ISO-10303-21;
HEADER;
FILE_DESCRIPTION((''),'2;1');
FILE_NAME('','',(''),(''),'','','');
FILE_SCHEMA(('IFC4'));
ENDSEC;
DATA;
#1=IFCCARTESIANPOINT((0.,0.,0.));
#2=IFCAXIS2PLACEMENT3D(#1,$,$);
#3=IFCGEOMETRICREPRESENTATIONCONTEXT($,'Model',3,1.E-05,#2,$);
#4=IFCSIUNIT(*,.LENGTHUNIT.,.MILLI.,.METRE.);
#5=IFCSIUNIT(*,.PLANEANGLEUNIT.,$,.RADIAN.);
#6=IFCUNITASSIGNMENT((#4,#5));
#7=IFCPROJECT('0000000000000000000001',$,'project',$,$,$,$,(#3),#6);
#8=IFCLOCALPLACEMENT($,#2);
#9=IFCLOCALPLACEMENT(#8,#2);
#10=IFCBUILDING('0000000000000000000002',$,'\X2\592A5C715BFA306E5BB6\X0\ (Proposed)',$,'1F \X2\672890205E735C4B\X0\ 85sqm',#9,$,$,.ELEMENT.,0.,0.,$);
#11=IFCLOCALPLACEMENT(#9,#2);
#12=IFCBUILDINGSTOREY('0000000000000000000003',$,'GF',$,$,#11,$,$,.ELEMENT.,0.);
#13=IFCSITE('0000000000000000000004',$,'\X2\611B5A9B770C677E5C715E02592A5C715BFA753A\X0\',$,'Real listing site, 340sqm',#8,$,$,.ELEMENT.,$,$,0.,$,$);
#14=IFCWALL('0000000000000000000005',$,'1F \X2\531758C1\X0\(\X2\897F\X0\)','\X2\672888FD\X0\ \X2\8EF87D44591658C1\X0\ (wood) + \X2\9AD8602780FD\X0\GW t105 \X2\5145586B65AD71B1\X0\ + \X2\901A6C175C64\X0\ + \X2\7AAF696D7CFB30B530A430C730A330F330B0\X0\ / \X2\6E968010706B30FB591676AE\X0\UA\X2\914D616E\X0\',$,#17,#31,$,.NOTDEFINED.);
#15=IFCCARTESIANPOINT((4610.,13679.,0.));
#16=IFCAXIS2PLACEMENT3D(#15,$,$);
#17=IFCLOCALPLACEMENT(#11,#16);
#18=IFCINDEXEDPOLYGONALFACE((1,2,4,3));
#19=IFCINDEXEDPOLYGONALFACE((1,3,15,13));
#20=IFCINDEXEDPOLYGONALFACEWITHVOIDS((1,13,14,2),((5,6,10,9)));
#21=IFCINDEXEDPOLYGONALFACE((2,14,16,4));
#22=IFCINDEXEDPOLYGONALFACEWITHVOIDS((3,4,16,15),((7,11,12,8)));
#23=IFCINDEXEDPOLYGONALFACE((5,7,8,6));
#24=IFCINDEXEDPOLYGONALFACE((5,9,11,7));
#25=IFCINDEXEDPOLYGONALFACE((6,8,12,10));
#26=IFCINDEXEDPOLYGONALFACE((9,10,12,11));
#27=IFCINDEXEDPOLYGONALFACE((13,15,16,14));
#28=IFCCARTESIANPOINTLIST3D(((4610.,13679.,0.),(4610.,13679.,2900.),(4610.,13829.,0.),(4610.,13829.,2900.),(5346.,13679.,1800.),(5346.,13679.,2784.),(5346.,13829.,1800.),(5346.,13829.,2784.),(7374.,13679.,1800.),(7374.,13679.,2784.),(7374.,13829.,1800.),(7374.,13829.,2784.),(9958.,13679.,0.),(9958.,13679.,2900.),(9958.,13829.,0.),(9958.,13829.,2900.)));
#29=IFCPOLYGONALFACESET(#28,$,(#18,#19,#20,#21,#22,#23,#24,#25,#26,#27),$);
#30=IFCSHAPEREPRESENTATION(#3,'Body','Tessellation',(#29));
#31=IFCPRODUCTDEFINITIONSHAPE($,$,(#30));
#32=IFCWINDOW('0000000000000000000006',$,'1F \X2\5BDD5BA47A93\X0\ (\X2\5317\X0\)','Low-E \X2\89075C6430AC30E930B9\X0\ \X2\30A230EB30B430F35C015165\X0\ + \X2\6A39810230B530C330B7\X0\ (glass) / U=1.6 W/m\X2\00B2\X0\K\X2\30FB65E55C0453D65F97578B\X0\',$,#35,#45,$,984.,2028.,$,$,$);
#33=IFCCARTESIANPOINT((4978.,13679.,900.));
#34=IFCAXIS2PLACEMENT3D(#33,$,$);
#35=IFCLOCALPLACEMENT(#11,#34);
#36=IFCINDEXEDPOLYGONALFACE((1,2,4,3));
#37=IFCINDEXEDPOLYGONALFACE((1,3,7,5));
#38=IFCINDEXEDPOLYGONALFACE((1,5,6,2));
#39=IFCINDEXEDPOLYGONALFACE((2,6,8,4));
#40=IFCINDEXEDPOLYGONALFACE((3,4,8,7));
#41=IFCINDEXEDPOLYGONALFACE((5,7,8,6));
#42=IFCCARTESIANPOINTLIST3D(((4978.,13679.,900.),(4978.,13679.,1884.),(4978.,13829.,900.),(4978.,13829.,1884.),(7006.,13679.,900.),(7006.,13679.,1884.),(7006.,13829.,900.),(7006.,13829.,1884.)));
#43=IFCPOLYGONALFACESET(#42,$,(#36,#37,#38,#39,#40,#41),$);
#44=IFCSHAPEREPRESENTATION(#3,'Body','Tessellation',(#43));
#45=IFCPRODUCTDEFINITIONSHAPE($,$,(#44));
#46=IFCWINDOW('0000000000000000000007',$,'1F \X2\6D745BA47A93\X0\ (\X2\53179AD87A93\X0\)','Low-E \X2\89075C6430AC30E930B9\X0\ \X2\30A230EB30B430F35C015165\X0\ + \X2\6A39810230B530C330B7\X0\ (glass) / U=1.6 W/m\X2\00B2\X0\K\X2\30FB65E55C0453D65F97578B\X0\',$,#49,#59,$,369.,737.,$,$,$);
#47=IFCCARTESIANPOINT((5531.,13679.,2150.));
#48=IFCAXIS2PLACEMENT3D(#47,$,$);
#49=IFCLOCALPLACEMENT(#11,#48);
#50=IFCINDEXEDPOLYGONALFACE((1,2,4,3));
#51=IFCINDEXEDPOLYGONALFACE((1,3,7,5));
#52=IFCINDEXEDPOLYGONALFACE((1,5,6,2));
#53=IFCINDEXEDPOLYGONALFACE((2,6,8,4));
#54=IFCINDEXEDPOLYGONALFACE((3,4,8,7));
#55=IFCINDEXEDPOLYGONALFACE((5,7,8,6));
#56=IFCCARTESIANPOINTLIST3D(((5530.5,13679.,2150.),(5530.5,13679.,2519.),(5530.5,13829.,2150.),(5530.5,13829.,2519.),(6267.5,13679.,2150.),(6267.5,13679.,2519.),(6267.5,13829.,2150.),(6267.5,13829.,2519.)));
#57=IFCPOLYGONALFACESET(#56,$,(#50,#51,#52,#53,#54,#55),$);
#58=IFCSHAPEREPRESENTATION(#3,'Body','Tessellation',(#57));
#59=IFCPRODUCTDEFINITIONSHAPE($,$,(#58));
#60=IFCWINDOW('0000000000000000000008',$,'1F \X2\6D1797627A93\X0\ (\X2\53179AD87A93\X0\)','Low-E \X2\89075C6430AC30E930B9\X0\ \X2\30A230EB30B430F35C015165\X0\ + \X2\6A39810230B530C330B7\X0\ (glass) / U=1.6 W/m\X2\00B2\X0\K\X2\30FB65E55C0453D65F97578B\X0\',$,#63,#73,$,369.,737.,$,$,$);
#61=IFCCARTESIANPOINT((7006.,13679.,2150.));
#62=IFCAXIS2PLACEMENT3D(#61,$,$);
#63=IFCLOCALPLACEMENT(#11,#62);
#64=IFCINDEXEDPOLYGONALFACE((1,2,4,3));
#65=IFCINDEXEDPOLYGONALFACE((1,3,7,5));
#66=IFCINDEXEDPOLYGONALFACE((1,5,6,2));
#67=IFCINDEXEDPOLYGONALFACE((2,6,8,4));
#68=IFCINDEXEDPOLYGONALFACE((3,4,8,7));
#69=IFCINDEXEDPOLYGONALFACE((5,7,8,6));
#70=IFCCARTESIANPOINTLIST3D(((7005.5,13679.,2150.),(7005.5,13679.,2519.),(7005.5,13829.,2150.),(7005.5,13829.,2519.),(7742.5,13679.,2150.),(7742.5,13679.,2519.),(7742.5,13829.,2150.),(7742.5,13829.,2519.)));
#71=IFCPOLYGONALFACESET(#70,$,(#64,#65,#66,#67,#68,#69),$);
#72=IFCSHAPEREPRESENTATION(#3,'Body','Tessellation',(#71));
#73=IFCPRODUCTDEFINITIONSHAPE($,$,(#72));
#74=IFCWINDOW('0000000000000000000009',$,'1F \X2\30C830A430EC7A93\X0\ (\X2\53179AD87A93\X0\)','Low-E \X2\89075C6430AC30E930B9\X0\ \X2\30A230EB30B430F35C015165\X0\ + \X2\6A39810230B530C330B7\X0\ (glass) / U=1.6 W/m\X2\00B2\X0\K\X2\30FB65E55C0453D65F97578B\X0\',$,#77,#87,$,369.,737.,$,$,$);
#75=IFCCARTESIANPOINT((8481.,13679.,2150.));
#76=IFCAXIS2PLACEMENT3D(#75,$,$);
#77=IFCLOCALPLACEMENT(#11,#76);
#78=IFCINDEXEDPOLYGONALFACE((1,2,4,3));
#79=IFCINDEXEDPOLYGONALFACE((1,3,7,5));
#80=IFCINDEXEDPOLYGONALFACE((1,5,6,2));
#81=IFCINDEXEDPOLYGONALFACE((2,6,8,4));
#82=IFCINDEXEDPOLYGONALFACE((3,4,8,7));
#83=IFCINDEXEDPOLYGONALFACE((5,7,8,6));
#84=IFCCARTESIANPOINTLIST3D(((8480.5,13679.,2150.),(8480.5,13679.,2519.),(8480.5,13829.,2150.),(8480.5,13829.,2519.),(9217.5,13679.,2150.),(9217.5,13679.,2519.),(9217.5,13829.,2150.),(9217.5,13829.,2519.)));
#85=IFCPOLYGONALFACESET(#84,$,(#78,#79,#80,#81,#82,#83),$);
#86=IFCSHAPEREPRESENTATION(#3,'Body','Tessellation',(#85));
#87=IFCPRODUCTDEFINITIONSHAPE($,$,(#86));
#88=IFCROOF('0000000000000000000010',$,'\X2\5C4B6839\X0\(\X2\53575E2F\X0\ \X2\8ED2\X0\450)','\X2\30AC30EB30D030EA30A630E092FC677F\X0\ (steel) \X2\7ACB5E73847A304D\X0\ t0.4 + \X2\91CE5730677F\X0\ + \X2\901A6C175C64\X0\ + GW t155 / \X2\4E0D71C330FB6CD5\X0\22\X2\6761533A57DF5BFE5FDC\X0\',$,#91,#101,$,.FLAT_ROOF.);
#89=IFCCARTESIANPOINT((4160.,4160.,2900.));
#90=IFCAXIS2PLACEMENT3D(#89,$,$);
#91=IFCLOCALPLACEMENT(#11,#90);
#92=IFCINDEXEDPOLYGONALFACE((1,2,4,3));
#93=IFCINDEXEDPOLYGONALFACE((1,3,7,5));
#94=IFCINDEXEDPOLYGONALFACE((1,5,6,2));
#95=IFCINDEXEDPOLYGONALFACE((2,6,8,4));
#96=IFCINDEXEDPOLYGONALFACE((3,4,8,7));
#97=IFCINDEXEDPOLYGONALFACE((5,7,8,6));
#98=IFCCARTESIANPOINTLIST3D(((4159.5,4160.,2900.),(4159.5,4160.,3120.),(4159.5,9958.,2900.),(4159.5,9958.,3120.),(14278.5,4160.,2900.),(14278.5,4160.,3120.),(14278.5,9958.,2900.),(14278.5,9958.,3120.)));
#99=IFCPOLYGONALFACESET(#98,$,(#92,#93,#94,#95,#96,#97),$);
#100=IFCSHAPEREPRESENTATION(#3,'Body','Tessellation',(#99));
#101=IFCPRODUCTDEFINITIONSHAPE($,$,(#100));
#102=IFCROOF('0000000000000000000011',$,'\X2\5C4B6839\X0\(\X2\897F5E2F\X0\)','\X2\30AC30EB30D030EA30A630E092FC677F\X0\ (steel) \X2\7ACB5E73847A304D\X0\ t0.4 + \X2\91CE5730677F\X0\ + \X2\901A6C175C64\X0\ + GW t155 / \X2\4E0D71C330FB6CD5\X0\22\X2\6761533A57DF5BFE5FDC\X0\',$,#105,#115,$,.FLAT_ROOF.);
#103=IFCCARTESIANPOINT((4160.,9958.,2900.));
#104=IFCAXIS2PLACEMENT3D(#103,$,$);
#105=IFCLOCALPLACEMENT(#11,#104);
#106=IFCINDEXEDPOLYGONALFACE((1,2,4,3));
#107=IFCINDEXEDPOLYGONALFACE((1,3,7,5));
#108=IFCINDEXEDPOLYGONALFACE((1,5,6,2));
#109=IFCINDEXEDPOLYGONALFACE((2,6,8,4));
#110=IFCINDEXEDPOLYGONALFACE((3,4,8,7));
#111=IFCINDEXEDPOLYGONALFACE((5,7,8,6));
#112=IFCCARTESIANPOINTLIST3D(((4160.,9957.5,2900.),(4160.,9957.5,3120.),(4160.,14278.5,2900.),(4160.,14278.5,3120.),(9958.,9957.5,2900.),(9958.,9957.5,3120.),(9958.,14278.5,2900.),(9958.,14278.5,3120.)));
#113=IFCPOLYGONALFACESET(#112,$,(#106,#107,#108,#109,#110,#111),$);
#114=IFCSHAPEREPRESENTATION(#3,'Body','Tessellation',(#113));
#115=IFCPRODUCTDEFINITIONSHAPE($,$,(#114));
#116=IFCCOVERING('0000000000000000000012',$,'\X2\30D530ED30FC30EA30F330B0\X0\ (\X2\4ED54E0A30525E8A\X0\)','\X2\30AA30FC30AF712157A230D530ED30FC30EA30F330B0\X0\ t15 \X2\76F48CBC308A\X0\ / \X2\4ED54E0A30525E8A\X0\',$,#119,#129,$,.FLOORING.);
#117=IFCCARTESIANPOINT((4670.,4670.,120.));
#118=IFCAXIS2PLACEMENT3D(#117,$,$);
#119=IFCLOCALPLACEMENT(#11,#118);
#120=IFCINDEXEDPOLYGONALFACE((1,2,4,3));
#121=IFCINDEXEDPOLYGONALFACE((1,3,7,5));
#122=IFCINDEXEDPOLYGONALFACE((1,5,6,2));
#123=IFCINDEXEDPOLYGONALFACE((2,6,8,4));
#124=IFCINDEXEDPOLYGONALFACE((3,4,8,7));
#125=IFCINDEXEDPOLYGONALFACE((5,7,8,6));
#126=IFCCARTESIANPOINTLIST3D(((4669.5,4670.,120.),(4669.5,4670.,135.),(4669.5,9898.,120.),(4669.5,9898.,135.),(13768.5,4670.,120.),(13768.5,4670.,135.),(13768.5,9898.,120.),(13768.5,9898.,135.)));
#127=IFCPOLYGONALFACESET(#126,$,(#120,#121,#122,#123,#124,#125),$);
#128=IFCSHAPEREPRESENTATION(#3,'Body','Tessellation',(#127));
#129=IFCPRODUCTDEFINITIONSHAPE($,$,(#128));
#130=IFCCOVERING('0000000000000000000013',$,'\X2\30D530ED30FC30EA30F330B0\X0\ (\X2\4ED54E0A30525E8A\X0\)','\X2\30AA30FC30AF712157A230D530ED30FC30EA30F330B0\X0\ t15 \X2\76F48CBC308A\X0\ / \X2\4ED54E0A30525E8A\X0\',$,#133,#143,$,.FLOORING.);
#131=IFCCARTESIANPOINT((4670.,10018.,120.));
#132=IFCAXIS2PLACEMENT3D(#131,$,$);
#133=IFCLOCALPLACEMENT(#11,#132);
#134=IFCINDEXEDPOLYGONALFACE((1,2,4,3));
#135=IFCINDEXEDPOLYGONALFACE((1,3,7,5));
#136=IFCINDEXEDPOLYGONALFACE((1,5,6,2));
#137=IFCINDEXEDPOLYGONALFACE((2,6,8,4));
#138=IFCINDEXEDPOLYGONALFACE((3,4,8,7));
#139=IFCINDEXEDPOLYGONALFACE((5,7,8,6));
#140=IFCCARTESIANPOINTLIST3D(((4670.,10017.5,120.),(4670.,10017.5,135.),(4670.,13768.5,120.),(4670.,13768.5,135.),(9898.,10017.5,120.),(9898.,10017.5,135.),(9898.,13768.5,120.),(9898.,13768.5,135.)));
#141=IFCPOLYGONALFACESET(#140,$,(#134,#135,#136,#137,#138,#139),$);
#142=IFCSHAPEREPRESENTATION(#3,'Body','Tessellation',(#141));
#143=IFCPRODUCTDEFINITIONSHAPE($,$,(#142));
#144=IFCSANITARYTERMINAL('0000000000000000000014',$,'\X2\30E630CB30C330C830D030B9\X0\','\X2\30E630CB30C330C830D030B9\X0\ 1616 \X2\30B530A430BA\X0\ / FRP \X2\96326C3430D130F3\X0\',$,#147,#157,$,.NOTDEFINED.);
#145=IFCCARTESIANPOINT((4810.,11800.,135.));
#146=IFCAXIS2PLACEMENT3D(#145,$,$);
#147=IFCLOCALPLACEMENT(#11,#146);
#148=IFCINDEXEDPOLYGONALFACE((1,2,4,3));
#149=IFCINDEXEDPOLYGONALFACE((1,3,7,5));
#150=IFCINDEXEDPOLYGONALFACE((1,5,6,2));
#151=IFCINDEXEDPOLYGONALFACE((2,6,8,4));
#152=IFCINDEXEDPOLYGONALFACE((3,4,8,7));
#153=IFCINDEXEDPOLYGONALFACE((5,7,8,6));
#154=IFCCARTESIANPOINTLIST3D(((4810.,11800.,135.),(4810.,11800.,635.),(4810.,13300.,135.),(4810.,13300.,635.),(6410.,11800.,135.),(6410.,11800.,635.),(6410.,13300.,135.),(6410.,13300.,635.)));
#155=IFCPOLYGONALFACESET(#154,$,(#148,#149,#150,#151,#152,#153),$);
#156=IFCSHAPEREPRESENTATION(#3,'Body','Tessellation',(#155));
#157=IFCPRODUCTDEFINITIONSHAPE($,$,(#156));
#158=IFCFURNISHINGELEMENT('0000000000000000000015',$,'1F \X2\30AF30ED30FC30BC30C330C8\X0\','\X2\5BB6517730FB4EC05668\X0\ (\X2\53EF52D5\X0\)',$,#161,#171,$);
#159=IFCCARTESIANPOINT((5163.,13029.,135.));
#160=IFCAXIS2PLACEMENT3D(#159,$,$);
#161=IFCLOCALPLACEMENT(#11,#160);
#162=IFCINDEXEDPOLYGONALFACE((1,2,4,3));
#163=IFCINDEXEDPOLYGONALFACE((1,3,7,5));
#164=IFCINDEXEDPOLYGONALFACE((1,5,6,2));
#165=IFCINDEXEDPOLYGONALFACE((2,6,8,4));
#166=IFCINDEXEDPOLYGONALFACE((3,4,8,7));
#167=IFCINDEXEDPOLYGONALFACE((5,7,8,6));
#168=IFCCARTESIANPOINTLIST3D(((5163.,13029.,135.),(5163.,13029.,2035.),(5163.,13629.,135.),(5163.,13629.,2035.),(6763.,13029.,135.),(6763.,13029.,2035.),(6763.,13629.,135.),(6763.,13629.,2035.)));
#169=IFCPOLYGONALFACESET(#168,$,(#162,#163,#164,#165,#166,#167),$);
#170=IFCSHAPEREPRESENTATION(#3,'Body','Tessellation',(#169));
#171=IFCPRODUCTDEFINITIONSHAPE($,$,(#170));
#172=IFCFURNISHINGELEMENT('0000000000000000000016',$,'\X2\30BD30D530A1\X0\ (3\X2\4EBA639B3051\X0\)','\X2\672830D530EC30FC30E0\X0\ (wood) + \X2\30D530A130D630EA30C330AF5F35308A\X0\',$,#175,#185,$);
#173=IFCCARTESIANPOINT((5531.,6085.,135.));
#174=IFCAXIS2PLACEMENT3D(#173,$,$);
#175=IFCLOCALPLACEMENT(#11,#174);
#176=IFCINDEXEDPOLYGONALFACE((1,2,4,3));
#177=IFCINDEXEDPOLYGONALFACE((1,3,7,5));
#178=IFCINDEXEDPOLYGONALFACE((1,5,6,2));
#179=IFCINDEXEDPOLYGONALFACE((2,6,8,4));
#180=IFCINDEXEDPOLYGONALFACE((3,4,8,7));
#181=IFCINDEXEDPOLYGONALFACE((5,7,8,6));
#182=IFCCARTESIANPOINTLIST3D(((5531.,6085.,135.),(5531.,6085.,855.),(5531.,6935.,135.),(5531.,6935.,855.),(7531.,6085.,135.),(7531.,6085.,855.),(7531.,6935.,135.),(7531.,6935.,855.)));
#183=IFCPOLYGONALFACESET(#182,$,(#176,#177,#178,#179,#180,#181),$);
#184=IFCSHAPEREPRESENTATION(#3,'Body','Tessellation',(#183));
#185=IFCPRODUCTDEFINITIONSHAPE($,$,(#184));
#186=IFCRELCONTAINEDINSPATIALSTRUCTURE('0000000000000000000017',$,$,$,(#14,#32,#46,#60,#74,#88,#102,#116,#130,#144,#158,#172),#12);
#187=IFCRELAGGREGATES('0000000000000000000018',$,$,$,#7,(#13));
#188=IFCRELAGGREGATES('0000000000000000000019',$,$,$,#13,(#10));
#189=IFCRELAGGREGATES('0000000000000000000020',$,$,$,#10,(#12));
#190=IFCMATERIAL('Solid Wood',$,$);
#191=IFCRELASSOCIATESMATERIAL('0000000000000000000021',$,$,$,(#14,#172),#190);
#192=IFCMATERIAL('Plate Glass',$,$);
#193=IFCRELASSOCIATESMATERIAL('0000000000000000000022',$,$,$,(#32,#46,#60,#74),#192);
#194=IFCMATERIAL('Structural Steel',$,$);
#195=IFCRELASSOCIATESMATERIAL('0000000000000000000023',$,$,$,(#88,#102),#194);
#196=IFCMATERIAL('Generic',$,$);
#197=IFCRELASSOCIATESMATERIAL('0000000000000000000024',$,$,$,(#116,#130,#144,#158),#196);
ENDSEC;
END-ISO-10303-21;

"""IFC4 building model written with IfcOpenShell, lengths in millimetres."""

from ifc_helpers import new_model, si_unit, frame, frame_2d, origin, place, context, project, spatial, rectangle, extrude, material, element, fill, save


model = new_model("IFC4")

# Units and contexts
model_context = context("Model", 3, precision=1e-05, world=origin())
ifc_project = project(units=[si_unit("LENGTHUNIT", "METRE", prefix="MILLI"), si_unit("PLANEANGLEUNIT", "RADIAN")], contexts=[model_context])

# Site, building, storey
site_placement = place(None, origin())
site = spatial("IfcSite", under=ifc_project, at=site_placement, Name="愛媛県松山市太山寺町", ObjectType="Real listing site, 340sqm", CompositionType="ELEMENT", RefElevation=0.0)
building_placement = place(site_placement, origin())
building = spatial("IfcBuilding", under=site, at=building_placement, Name="太山寺の家 (Proposed)", ObjectType="1F 木造平屋 85sqm", CompositionType="ELEMENT", ElevationOfRefHeight=0.0, ElevationOfTerrain=0.0)
storey_placement = place(building_placement, origin())
storey = spatial("IfcBuildingStorey", under=building, at=storey_placement, Name="GF", CompositionType="ELEMENT", Elevation=0.0)

# Shared definitions
ifc_material_1 = material(Name="Solid Wood")

# Shared definitions
ifc_material_2 = material(Name="Plate Glass")

# Wall, openings, windows
wall_1_placement = place(storey_placement, frame((4610.0, 13679.0, 0.0)))
wall_1 = element("IfcWall", 1, at=wall_1_placement, inside=storey, material=ifc_material_1, Name="1F 北壁(西)", Description="木製 軸組外壁 (wood) + 高性能GW t105 充填断熱 + 通気層 + 窯業系サイディング / 準耐火・外皮UA配慮", PredefinedType="NOTDEFINED", context=model_context, shape_type="SweptSolid", body=[
    extrude(rectangle(XDim=5348.0, YDim=150.0, at=frame_2d((2674.0, 75.0))), frame((4610.0, 13679.0, 0.0)), (0.0, 0.0, 1.0), 2900.0),
])
opening_1_placement = place(storey_placement, frame((4978.0, 13679.0, 900.0)))
opening_1 = element("IfcOpeningElement", 2, at=opening_1_placement, cuts=wall_1, PredefinedType="NOTDEFINED", context=model_context, shape_type="SweptSolid", body=[
    extrude(rectangle(XDim=2028.0, YDim=150.0, at=frame_2d((1014.0, 75.0))), frame((4978.0, 13679.0, 900.0)), (0.0, 0.0, 1.0), 984.0),
])
opening_2_placement = place(storey_placement, frame((5531.0, 13679.0, 2150.0)))
opening_2 = element("IfcOpeningElement", 3, at=opening_2_placement, cuts=wall_1, PredefinedType="NOTDEFINED", context=model_context, shape_type="SweptSolid", body=[
    extrude(rectangle(XDim=737.0, YDim=150.0, at=frame_2d((368.0, 75.0))), frame((5531.0, 13679.0, 2150.0)), (0.0, 0.0, 1.0), 369.0),
])
opening_3_placement = place(storey_placement, frame((7006.0, 13679.0, 2150.0)))
opening_3 = element("IfcOpeningElement", 4, at=opening_3_placement, cuts=wall_1, PredefinedType="NOTDEFINED", context=model_context, shape_type="SweptSolid", body=[
    extrude(rectangle(XDim=737.0, YDim=150.0, at=frame_2d((368.0, 75.0))), frame((7006.0, 13679.0, 2150.0)), (0.0, 0.0, 1.0), 369.0),
])
opening_4_placement = place(storey_placement, frame((8481.0, 13679.0, 2150.0)))
opening_4 = element("IfcOpeningElement", 5, at=opening_4_placement, cuts=wall_1, PredefinedType="NOTDEFINED", context=model_context, shape_type="SweptSolid", body=[
    extrude(rectangle(XDim=737.0, YDim=150.0, at=frame_2d((368.0, 75.0))), frame((8481.0, 13679.0, 2150.0)), (0.0, 0.0, 1.0), 369.0),
])
window_1_placement = place(storey_placement, frame((4978.0, 13679.0, 900.0)))
window_1 = element("IfcWindow", 6, at=window_1_placement, inside=storey, material=ifc_material_2, Name="1F 寝室窓 (北)", Description="Low-E 複層ガラス アルゴン封入 + 樹脂サッシ (glass) / U=1.6 W/m²K・日射取得型", OverallHeight=984.0, OverallWidth=2028.0, context=model_context, shape_type="SweptSolid", body=[
    extrude(rectangle(XDim=2028.0, YDim=150.0, at=frame_2d((1014.0, 75.0))), frame((4978.0, 13679.0, 900.0)), (0.0, 0.0, 1.0), 984.0),
])
fill(opening_1, window_1)
window_2_placement = place(storey_placement, frame((5531.0, 13679.0, 2150.0)))
window_2 = element("IfcWindow", 7, at=window_2_placement, inside=storey, material=ifc_material_2, Name="1F 浴室窓 (北高窓)", Description="Low-E 複層ガラス アルゴン封入 + 樹脂サッシ (glass) / U=1.6 W/m²K・日射取得型", OverallHeight=369.0, OverallWidth=737.0, context=model_context, shape_type="SweptSolid", body=[
    extrude(rectangle(XDim=737.0, YDim=150.0, at=frame_2d((368.0, 75.0))), frame((5531.0, 13679.0, 2150.0)), (0.0, 0.0, 1.0), 369.0),
])
fill(opening_2, window_2)
window_3_placement = place(storey_placement, frame((7006.0, 13679.0, 2150.0)))
window_3 = element("IfcWindow", 8, at=window_3_placement, inside=storey, material=ifc_material_2, Name="1F 洗面窓 (北高窓)", Description="Low-E 複層ガラス アルゴン封入 + 樹脂サッシ (glass) / U=1.6 W/m²K・日射取得型", OverallHeight=369.0, OverallWidth=737.0, context=model_context, shape_type="SweptSolid", body=[
    extrude(rectangle(XDim=737.0, YDim=150.0, at=frame_2d((368.0, 75.0))), frame((7006.0, 13679.0, 2150.0)), (0.0, 0.0, 1.0), 369.0),
])
fill(opening_3, window_3)
window_4_placement = place(storey_placement, frame((8481.0, 13679.0, 2150.0)))
window_4 = element("IfcWindow", 9, at=window_4_placement, inside=storey, material=ifc_material_2, Name="1F トイレ窓 (北高窓)", Description="Low-E 複層ガラス アルゴン封入 + 樹脂サッシ (glass) / U=1.6 W/m²K・日射取得型", OverallHeight=369.0, OverallWidth=737.0, context=model_context, shape_type="SweptSolid", body=[
    extrude(rectangle(XDim=737.0, YDim=150.0, at=frame_2d((368.0, 75.0))), frame((8481.0, 13679.0, 2150.0)), (0.0, 0.0, 1.0), 369.0),
])
fill(opening_4, window_4)

# Roofs
ifc_material_3 = material(Name="Structural Steel")
roof_1_placement = place(storey_placement, frame((4160.0, 4160.0, 2900.0)))
element("IfcRoof", 10, at=roof_1_placement, inside=storey, material=ifc_material_3, Name="屋根(南帯 軒450)", Description="ガルバリウム鋼板 (steel) 立平葺き t0.4 + 野地板 + 通気層 + GW t155 / 不燃・法22条区域対応", PredefinedType="FLAT_ROOF", context=model_context, shape_type="SweptSolid", body=[
    extrude(rectangle(XDim=10119.0, YDim=5798.0, at=frame_2d((5059.0, 2899.0))), frame((4160.0, 4160.0, 2900.0)), (0.0, 0.0, 1.0), 220.0),
])
roof_2_placement = place(storey_placement, frame((4160.0, 9958.0, 2900.0)))
element("IfcRoof", 11, at=roof_2_placement, inside=storey, material=ifc_material_3, Name="屋根(西帯)", Description="ガルバリウム鋼板 (steel) 立平葺き t0.4 + 野地板 + 通気層 + GW t155 / 不燃・法22条区域対応", PredefinedType="FLAT_ROOF", context=model_context, shape_type="SweptSolid", body=[
    extrude(rectangle(XDim=5798.0, YDim=4321.0, at=frame_2d((2899.0, 2160.0))), frame((4160.0, 9958.0, 2900.0)), (0.0, 0.0, 1.0), 220.0),
])

# Coverings
ifc_material_4 = material(Name="Generic")
covering_1_placement = place(storey_placement, frame((4670.0, 4670.0, 120.0)))
element("IfcCovering", 12, at=covering_1_placement, inside=storey, material=ifc_material_4, Name="フローリング (仕上げ床)", Description="オーク無垢フローリング t15 直貼り / 仕上げ床", PredefinedType="FLOORING", context=model_context, shape_type="SweptSolid", body=[
    extrude(rectangle(XDim=9099.0, YDim=5228.0, at=frame_2d((4549.0, 2614.0))), frame((4670.0, 4670.0, 120.0)), (0.0, 0.0, 1.0), 15.0),
])
covering_2_placement = place(storey_placement, frame((4670.0, 10018.0, 120.0)))
element("IfcCovering", 13, at=covering_2_placement, inside=storey, material=ifc_material_4, Name="フローリング (仕上げ床)", Description="オーク無垢フローリング t15 直貼り / 仕上げ床", PredefinedType="FLOORING", context=model_context, shape_type="SweptSolid", body=[
    extrude(rectangle(XDim=5228.0, YDim=3751.0, at=frame_2d((2614.0, 1875.0))), frame((4670.0, 10018.0, 120.0)), (0.0, 0.0, 1.0), 15.0),
])

# Sanitary terminal
sanitary_terminal_placement = place(storey_placement, frame((4810.0, 11800.0, 135.0)))
element("IfcSanitaryTerminal", 14, at=sanitary_terminal_placement, inside=storey, material=ifc_material_4, Name="ユニットバス", Description="ユニットバス 1616 サイズ / FRP 防水パン", PredefinedType="NOTDEFINED", context=model_context, shape_type="SweptSolid", body=[
    extrude(rectangle(XDim=1600.0, YDim=1500.0, at=frame_2d((800.0, 750.0))), frame((4810.0, 11800.0, 135.0)), (0.0, 0.0, 1.0), 500.0),
])

# Furnishing elements
furnishing_1_placement = place(storey_placement, frame((5163.0, 13029.0, 135.0)))
element("IfcFurnishingElement", 15, at=furnishing_1_placement, inside=storey, material=ifc_material_4, Name="1F クローゼット", Description="家具・什器 (可動)", context=model_context, shape_type="SweptSolid", body=[
    extrude(rectangle(XDim=1600.0, YDim=600.0, at=frame_2d((800.0, 300.0))), frame((5163.0, 13029.0, 135.0)), (0.0, 0.0, 1.0), 1900.0),
])
furnishing_2_placement = place(storey_placement, frame((5531.0, 6085.0, 135.0)))
element("IfcFurnishingElement", 16, at=furnishing_2_placement, inside=storey, material=ifc_material_1, Name="ソファ (3人掛け)", Description="木フレーム (wood) + ファブリック張り", context=model_context, shape_type="SweptSolid", body=[
    extrude(rectangle(XDim=2000.0, YDim=850.0, at=frame_2d((1000.0, 425.0))), frame((5531.0, 6085.0, 135.0)), (0.0, 0.0, 1.0), 720.0),
])

save(model, "model.ifc")
